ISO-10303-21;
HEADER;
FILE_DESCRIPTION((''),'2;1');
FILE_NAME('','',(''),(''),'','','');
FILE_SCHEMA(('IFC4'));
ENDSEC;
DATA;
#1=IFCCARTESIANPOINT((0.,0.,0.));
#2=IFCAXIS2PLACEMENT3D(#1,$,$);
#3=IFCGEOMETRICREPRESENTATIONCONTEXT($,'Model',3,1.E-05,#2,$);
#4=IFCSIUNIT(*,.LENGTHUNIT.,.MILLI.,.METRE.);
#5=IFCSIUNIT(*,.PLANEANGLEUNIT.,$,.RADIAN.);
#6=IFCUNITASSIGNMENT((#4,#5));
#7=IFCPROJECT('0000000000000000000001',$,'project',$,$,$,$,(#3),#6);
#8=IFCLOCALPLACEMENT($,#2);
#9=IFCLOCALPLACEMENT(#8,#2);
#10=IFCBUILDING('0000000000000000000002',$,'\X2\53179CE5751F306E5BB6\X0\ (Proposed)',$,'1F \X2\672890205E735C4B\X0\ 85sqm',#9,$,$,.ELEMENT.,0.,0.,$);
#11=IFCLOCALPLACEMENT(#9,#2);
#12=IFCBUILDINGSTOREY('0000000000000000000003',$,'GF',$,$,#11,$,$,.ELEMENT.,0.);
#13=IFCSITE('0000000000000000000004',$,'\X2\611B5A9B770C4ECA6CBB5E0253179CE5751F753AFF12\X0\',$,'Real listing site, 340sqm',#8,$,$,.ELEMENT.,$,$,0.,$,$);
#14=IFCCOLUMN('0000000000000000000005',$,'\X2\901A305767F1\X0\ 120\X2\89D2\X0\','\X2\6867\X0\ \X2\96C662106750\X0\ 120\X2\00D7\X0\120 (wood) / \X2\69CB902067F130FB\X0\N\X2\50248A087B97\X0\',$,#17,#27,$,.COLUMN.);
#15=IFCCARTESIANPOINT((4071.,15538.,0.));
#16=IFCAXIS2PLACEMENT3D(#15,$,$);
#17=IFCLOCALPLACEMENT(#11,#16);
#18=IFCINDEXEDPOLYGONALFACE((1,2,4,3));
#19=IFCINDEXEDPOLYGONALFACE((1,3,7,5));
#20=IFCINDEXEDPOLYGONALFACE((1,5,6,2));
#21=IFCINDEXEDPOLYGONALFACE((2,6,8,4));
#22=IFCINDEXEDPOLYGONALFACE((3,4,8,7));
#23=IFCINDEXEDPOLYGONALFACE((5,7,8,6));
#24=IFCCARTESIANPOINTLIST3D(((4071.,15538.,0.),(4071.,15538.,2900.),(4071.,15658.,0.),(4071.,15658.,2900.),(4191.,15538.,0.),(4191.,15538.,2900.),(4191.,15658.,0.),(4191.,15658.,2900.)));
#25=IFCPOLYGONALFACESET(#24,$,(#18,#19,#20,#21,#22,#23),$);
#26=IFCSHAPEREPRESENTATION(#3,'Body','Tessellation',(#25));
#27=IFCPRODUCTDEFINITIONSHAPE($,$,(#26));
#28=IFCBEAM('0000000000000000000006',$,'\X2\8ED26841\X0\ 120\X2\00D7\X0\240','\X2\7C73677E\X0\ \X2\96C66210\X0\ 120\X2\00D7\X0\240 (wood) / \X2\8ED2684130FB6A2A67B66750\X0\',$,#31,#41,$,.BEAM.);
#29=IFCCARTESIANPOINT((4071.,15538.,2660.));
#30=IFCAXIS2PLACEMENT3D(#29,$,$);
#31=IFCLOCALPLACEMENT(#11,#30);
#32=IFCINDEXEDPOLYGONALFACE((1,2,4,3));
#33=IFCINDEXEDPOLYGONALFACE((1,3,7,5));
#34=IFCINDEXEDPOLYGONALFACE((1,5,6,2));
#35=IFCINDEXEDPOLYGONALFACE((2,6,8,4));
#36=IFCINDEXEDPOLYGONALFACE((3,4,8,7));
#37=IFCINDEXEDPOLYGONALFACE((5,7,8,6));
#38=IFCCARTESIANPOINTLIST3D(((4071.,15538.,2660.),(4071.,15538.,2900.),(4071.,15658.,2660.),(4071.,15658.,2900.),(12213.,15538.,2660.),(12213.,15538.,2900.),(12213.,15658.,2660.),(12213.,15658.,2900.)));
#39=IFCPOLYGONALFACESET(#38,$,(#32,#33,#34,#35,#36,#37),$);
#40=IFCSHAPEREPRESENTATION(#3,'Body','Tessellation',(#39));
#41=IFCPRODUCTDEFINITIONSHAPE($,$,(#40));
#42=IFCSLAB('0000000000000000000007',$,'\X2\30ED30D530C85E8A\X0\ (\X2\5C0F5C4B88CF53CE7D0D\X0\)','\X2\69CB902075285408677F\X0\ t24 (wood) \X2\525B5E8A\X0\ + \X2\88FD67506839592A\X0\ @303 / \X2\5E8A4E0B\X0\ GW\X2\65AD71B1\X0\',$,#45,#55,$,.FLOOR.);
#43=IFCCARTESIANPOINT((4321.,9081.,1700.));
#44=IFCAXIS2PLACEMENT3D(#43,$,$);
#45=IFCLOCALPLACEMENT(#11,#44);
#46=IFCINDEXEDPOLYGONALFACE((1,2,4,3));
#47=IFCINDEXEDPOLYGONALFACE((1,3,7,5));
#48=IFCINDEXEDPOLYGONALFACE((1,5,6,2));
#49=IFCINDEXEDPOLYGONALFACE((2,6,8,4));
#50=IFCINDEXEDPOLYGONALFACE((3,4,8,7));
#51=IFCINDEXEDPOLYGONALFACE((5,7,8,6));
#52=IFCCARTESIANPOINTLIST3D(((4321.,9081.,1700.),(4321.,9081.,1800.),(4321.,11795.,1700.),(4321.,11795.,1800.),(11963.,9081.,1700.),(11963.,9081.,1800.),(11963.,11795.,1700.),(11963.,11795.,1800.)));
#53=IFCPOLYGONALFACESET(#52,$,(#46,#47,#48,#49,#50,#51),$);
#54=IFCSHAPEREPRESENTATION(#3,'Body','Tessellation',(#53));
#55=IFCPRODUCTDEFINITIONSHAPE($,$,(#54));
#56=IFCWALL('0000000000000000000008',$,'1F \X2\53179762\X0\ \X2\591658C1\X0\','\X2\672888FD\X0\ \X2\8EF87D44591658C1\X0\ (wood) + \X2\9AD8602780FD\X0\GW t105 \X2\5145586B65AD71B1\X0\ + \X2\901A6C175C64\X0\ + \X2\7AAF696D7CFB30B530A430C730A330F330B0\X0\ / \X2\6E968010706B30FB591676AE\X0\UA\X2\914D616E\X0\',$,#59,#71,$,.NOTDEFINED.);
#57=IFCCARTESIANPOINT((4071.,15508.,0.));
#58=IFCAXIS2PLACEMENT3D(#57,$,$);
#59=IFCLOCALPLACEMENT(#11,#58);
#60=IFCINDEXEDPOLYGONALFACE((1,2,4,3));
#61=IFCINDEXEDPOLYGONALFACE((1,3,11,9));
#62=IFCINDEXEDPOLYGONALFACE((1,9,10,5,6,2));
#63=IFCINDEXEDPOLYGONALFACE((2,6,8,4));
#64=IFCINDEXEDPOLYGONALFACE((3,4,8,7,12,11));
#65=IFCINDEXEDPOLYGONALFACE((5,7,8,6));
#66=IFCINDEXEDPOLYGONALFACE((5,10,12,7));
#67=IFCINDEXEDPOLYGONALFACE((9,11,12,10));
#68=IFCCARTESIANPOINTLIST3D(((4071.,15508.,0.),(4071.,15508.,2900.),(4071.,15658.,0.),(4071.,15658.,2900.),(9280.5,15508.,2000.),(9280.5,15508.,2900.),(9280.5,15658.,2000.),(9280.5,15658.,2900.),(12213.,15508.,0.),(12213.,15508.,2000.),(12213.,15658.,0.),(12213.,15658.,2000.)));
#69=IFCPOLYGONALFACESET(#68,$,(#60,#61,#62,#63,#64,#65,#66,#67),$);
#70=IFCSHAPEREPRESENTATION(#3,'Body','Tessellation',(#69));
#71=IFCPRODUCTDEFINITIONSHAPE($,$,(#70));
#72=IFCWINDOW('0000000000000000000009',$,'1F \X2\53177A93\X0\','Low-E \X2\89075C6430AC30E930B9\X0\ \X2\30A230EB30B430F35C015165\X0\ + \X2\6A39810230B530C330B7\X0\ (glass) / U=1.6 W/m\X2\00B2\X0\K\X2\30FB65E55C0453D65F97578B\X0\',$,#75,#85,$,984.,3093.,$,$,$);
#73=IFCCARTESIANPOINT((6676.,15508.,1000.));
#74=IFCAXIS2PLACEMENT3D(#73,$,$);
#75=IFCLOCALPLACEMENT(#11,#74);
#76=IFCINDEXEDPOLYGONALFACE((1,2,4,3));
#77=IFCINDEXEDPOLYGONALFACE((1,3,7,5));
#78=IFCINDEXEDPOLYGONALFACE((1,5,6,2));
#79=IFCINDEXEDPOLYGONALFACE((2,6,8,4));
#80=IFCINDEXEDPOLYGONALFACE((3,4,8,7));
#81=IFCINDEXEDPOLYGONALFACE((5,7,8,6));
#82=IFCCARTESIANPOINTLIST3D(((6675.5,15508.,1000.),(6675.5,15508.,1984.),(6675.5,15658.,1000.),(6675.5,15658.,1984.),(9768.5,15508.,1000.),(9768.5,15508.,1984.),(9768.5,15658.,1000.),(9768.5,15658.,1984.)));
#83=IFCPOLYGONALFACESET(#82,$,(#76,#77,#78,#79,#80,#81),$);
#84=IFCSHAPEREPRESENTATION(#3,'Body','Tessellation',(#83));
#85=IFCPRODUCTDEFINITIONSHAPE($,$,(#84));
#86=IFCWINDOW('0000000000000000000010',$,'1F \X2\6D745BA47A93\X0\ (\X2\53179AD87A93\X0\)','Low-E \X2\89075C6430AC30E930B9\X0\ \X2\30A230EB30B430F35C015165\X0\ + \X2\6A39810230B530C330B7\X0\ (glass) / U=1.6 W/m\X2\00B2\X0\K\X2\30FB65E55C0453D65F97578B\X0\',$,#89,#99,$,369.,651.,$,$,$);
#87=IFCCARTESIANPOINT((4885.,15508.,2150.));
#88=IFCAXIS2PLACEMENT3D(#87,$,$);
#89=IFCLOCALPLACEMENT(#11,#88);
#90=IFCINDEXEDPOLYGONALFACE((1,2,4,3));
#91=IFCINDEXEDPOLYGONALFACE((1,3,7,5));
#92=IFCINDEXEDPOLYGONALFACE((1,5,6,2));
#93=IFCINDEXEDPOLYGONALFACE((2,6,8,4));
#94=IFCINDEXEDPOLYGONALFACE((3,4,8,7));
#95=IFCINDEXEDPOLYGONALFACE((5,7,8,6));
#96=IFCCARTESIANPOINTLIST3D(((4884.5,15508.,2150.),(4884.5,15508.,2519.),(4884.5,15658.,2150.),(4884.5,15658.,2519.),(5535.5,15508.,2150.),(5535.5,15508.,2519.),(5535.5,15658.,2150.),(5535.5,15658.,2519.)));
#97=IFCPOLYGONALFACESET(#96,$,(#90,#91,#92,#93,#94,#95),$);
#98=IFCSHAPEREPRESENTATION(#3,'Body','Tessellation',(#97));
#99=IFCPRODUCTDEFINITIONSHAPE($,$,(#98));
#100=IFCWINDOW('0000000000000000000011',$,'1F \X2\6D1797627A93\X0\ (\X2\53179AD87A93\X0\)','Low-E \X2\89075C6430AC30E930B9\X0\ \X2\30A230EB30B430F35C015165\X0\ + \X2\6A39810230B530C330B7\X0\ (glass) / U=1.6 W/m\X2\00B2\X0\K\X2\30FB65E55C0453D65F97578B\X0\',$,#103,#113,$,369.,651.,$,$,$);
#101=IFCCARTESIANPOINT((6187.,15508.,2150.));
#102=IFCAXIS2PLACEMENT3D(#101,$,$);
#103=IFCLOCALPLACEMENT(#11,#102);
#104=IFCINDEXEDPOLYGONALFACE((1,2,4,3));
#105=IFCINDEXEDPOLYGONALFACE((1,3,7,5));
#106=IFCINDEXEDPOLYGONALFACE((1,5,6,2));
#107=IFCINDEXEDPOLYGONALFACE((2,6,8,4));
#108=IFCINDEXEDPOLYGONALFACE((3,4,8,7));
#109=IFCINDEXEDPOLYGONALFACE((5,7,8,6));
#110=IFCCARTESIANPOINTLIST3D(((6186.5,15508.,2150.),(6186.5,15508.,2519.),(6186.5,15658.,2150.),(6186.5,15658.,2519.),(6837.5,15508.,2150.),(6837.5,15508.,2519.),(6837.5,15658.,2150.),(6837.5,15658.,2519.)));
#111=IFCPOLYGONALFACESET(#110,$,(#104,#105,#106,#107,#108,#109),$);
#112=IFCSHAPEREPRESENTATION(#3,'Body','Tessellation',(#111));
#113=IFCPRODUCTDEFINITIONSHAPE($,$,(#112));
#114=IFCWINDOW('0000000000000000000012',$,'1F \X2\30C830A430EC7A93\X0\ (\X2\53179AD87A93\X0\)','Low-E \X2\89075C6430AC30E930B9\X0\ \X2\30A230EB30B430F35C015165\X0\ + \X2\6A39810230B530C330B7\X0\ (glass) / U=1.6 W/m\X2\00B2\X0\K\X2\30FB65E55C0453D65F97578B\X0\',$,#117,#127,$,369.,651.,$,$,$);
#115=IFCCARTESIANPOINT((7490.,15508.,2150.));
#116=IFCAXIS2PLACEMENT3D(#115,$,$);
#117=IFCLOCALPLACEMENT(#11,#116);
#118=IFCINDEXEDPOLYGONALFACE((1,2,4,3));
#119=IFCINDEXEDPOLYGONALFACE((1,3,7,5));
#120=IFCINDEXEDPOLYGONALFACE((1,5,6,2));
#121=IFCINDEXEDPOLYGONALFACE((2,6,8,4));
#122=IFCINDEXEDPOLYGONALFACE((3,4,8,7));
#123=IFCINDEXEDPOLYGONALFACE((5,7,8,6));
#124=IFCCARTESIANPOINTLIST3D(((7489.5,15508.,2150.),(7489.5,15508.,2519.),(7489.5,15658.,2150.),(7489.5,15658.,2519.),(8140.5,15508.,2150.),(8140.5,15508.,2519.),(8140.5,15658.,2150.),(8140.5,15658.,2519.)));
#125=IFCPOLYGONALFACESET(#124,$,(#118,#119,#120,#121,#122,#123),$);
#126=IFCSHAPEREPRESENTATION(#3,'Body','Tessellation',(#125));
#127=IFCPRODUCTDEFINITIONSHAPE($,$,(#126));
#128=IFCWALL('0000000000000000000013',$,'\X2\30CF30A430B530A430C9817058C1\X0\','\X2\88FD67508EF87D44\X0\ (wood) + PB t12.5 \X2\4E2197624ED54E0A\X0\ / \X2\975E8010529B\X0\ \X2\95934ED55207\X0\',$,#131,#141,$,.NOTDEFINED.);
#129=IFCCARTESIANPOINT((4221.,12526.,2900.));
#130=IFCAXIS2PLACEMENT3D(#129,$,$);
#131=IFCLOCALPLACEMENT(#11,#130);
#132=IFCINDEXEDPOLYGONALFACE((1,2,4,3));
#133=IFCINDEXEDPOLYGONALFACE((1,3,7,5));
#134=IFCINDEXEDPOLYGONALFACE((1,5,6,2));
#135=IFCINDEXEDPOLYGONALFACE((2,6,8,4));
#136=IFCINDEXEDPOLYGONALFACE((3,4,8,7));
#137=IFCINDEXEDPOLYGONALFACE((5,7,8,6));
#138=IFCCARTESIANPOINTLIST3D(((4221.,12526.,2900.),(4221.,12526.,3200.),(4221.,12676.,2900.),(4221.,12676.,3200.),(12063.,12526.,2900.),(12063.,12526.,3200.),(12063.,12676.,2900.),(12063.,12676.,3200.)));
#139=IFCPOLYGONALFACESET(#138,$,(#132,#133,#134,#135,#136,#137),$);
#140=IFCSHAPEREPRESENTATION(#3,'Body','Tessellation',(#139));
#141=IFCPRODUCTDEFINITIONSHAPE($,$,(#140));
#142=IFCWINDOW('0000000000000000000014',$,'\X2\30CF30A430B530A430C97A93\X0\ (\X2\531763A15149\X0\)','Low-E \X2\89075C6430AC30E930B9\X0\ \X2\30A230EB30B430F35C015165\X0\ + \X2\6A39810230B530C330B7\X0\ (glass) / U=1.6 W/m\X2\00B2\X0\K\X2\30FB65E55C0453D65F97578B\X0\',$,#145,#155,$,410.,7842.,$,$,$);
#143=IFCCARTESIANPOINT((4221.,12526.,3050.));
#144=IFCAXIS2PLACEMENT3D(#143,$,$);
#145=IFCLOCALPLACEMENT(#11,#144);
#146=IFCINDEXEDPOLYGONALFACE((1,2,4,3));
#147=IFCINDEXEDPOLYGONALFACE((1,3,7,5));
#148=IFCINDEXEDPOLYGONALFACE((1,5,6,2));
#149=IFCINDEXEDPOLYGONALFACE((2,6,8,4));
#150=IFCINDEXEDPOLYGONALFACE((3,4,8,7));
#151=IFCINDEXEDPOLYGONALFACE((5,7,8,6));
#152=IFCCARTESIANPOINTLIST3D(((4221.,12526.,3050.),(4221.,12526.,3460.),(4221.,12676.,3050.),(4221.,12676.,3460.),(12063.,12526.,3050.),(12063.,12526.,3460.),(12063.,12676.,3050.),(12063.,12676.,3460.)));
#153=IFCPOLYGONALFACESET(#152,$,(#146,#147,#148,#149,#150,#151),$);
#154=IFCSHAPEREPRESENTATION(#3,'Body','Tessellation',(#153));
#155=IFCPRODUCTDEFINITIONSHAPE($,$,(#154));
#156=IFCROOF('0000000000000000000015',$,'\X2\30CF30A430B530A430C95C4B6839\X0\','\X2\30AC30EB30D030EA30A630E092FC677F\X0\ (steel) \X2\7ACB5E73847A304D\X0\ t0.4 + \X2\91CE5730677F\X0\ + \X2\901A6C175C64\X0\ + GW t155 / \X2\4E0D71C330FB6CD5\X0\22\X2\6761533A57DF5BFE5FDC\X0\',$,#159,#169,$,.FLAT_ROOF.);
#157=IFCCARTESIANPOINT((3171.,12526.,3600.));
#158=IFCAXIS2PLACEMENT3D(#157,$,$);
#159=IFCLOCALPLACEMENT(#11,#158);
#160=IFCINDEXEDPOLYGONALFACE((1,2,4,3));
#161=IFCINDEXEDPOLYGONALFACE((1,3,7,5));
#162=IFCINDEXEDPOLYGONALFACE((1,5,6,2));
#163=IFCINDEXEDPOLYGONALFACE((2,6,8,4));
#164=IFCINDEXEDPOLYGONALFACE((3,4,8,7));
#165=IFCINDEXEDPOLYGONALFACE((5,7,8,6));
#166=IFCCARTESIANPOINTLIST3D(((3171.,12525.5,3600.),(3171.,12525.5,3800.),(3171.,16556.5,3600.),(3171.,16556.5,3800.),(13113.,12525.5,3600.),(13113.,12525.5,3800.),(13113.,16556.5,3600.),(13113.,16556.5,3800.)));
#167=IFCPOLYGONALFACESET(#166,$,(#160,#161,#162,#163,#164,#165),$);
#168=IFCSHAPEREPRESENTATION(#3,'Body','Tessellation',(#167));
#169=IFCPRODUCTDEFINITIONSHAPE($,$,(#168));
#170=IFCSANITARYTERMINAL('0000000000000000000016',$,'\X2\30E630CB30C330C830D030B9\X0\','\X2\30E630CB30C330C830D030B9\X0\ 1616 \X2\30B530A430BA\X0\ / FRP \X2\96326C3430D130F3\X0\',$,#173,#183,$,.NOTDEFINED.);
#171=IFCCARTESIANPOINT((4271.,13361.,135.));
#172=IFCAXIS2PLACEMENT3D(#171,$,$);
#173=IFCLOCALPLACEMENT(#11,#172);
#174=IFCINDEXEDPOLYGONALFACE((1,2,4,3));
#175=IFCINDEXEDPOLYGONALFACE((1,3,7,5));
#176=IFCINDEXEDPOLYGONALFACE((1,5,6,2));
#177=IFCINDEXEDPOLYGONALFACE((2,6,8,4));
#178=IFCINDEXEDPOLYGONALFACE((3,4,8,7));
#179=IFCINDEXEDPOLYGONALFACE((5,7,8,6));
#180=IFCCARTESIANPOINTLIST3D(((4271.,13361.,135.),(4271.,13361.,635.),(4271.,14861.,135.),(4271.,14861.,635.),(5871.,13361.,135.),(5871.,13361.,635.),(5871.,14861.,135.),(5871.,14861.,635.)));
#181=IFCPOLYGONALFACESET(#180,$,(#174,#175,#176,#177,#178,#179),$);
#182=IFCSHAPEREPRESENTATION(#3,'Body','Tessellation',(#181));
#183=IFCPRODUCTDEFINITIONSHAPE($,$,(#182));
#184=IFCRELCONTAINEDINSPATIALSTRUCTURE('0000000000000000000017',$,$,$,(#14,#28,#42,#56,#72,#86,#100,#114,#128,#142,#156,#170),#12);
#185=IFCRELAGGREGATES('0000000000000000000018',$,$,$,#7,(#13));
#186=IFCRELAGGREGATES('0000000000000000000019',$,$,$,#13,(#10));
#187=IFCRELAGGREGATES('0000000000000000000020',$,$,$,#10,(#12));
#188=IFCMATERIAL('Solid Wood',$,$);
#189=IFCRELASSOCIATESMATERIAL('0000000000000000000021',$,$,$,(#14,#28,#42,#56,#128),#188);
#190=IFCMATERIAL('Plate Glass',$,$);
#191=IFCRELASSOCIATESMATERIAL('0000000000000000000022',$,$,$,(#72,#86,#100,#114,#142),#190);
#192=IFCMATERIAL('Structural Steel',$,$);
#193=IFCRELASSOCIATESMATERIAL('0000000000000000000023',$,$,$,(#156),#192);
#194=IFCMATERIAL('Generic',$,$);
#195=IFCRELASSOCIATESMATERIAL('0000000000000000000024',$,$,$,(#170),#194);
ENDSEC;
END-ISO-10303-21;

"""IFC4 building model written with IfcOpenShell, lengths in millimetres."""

from ifc_helpers import new_model, si_unit, frame, frame_2d, origin, place, context, project, spatial, rectangle, extrude, material, element, fill, save


model = new_model("IFC4")

# Units and contexts
model_context = context("Model", 3, precision=1e-05, world=origin())
ifc_project = project(units=[si_unit("LENGTHUNIT", "METRE", prefix="MILLI"), si_unit("PLANEANGLEUNIT", "RADIAN")], contexts=[model_context])

# Site, building, storey
site_placement = place(None, origin())
site = spatial("IfcSite", under=ifc_project, at=site_placement, Name="愛媛県今治市北鳥生町２", ObjectType="Real listing site, 340sqm", CompositionType="ELEMENT", RefElevation=0.0)
building_placement = place(site_placement, origin())
building = spatial("IfcBuilding", under=site, at=building_placement, Name="北鳥生の家 (Proposed)", ObjectType="1F 木造平屋 85sqm", CompositionType="ELEMENT", ElevationOfRefHeight=0.0, ElevationOfTerrain=0.0)
storey_placement = place(building_placement, origin())
storey = spatial("IfcBuildingStorey", under=building, at=storey_placement, Name="GF", CompositionType="ELEMENT", Elevation=0.0)

# Column
ifc_material_1 = material(Name="Solid Wood")
column_1_placement = place(storey_placement, frame((4071.0, 15538.0, 0.0)))
element("IfcColumn", 1, at=column_1_placement, inside=storey, material=ifc_material_1, Name="通し柱 120角", Description="桧 集成材 120×120 (wood) / 構造柱・N値計算", PredefinedType="COLUMN", context=model_context, shape_type="SweptSolid", body=[
    extrude(rectangle(XDim=120.0, YDim=120.0, at=frame_2d((60.0, 60.0))), frame((4071.0, 15538.0, 0.0)), (0.0, 0.0, 1.0), 2900.0),
])

# Beam
beam_1_placement = place(storey_placement, frame((4071.0, 15538.0, 2660.0)))
element("IfcBeam", 2, at=beam_1_placement, inside=storey, material=ifc_material_1, Name="軒桁 120×240", Description="米松 集成 120×240 (wood) / 軒桁・横架材", PredefinedType="BEAM", context=model_context, shape_type="SweptSolid", body=[
    extrude(rectangle(XDim=8142.0, YDim=120.0, at=frame_2d((4071.0, 60.0))), frame((4071.0, 15538.0, 2660.0)), (0.0, 0.0, 1.0), 240.0),
])

# Slab
slab_placement = place(storey_placement, frame((4321.0, 9081.0, 1700.0)))
element("IfcSlab", 3, at=slab_placement, inside=storey, material=ifc_material_1, Name="ロフト床 (小屋裏収納)", Description="構造用合板 t24 (wood) 剛床 + 製材根太 @303 / 床下 GW断熱", PredefinedType="FLOOR", context=model_context, shape_type="SweptSolid", body=[
    extrude(rectangle(XDim=7642.0, YDim=2714.0, at=frame_2d((3821.0, 1357.0))), frame((4321.0, 9081.0, 1700.0)), (0.0, 0.0, 1.0), 100.0),
])

# Wall, openings, windows
wall_1_placement = place(storey_placement, frame((4071.0, 15508.0, 0.0)))
wall_1 = element("IfcWall", 4, at=wall_1_placement, inside=storey, material=ifc_material_1, Name="1F 北面 外壁", Description="木製 軸組外壁 (wood) + 高性能GW t105 充填断熱 + 通気層 + 窯業系サイディング / 準耐火・外皮UA配慮", PredefinedType="NOTDEFINED", context=model_context, shape_type="SweptSolid", body=[
    extrude(rectangle(XDim=8142.0, YDim=150.0, at=frame_2d((4071.0, 75.0))), frame((4071.0, 15508.0, 0.0)), (0.0, 0.0, 1.0), 2900.0),
])
opening_1_placement = place(storey_placement, frame((6676.0, 15508.0, 1000.0)))
opening_1 = element("IfcOpeningElement", 5, at=opening_1_placement, cuts=wall_1, PredefinedType="NOTDEFINED", context=model_context, shape_type="SweptSolid", body=[
    extrude(rectangle(XDim=3093.0, YDim=150.0, at=frame_2d((1546.0, 75.0))), frame((6676.0, 15508.0, 1000.0)), (0.0, 0.0, 1.0), 984.0),
])
opening_2_placement = place(storey_placement, frame((4885.0, 15508.0, 2150.0)))
opening_2 = element("IfcOpeningElement", 6, at=opening_2_placement, cuts=wall_1, PredefinedType="NOTDEFINED", context=model_context, shape_type="SweptSolid", body=[
    extrude(rectangle(XDim=651.0, YDim=150.0, at=frame_2d((325.0, 75.0))), frame((4885.0, 15508.0, 2150.0)), (0.0, 0.0, 1.0), 369.0),
])
opening_3_placement = place(storey_placement, frame((6187.0, 15508.0, 2150.0)))
opening_3 = element("IfcOpeningElement", 7, at=opening_3_placement, cuts=wall_1, PredefinedType="NOTDEFINED", context=model_context, shape_type="SweptSolid", body=[
    extrude(rectangle(XDim=651.0, YDim=150.0, at=frame_2d((325.0, 75.0))), frame((6187.0, 15508.0, 2150.0)), (0.0, 0.0, 1.0), 369.0),
])
opening_4_placement = place(storey_placement, frame((7490.0, 15508.0, 2150.0)))
opening_4 = element("IfcOpeningElement", 8, at=opening_4_placement, cuts=wall_1, PredefinedType="NOTDEFINED", context=model_context, shape_type="SweptSolid", body=[
    extrude(rectangle(XDim=651.0, YDim=150.0, at=frame_2d((325.0, 75.0))), frame((7490.0, 15508.0, 2150.0)), (0.0, 0.0, 1.0), 369.0),
])
ifc_material_2 = material(Name="Plate Glass")
window_1_placement = place(storey_placement, frame((6676.0, 15508.0, 1000.0)))
window_1 = element("IfcWindow", 9, at=window_1_placement, inside=storey, material=ifc_material_2, Name="1F 北窓", Description="Low-E 複層ガラス アルゴン封入 + 樹脂サッシ (glass) / U=1.6 W/m²K・日射取得型", OverallHeight=984.0, OverallWidth=3093.0, context=model_context, shape_type="SweptSolid", body=[
    extrude(rectangle(XDim=3093.0, YDim=150.0, at=frame_2d((1546.0, 75.0))), frame((6676.0, 15508.0, 1000.0)), (0.0, 0.0, 1.0), 984.0),
])
fill(opening_1, window_1)
window_2_placement = place(storey_placement, frame((4885.0, 15508.0, 2150.0)))
window_2 = element("IfcWindow", 10, at=window_2_placement, inside=storey, material=ifc_material_2, Name="1F 浴室窓 (北高窓)", Description="Low-E 複層ガラス アルゴン封入 + 樹脂サッシ (glass) / U=1.6 W/m²K・日射取得型", OverallHeight=369.0, OverallWidth=651.0, context=model_context, shape_type="SweptSolid", body=[
    extrude(rectangle(XDim=651.0, YDim=150.0, at=frame_2d((325.0, 75.0))), frame((4885.0, 15508.0, 2150.0)), (0.0, 0.0, 1.0), 369.0),
])
fill(opening_2, window_2)
window_3_placement = place(storey_placement, frame((6187.0, 15508.0, 2150.0)))
window_3 = element("IfcWindow", 11, at=window_3_placement, inside=storey, material=ifc_material_2, Name="1F 洗面窓 (北高窓)", Description="Low-E 複層ガラス アルゴン封入 + 樹脂サッシ (glass) / U=1.6 W/m²K・日射取得型", OverallHeight=369.0, OverallWidth=651.0, context=model_context, shape_type="SweptSolid", body=[
    extrude(rectangle(XDim=651.0, YDim=150.0, at=frame_2d((325.0, 75.0))), frame((6187.0, 15508.0, 2150.0)), (0.0, 0.0, 1.0), 369.0),
])
fill(opening_3, window_3)
window_4_placement = place(storey_placement, frame((7490.0, 15508.0, 2150.0)))
window_4 = element("IfcWindow", 12, at=window_4_placement, inside=storey, material=ifc_material_2, Name="1F トイレ窓 (北高窓)", Description="Low-E 複層ガラス アルゴン封入 + 樹脂サッシ (glass) / U=1.6 W/m²K・日射取得型", OverallHeight=369.0, OverallWidth=651.0, context=model_context, shape_type="SweptSolid", body=[
    extrude(rectangle(XDim=651.0, YDim=150.0, at=frame_2d((325.0, 75.0))), frame((7490.0, 15508.0, 2150.0)), (0.0, 0.0, 1.0), 369.0),
])
fill(opening_4, window_4)

# Wall, opening, window
wall_2_placement = place(storey_placement, frame((4221.0, 12526.0, 2900.0)))
wall_2 = element("IfcWall", 13, at=wall_2_placement, inside=storey, material=ifc_material_1, Name="ハイサイド腰壁", Description="製材軸組 (wood) + PB t12.5 両面仕上 / 非耐力 間仕切", PredefinedType="NOTDEFINED", context=model_context, shape_type="SweptSolid", body=[
    extrude(rectangle(XDim=7842.0, YDim=150.0, at=frame_2d((3921.0, 75.0))), frame((4221.0, 12526.0, 2900.0)), (0.0, 0.0, 1.0), 700.0),
])
opening_5_placement = place(storey_placement, frame((4221.0, 12526.0, 3050.0)))
opening_5 = element("IfcOpeningElement", 14, at=opening_5_placement, cuts=wall_2, PredefinedType="NOTDEFINED", context=model_context, shape_type="SweptSolid", body=[
    extrude(rectangle(XDim=7842.0, YDim=150.0, at=frame_2d((3921.0, 75.0))), frame((4221.0, 12526.0, 3050.0)), (0.0, 0.0, 1.0), 410.0),
])
window_5_placement = place(storey_placement, frame((4221.0, 12526.0, 3050.0)))
window_5 = element("IfcWindow", 15, at=window_5_placement, inside=storey, material=ifc_material_2, Name="ハイサイド窓 (北採光)", Description="Low-E 複層ガラス アルゴン封入 + 樹脂サッシ (glass) / U=1.6 W/m²K・日射取得型", OverallHeight=410.0, OverallWidth=7842.0, context=model_context, shape_type="SweptSolid", body=[
    extrude(rectangle(XDim=7842.0, YDim=150.0, at=frame_2d((3921.0, 75.0))), frame((4221.0, 12526.0, 3050.0)), (0.0, 0.0, 1.0), 410.0),
])
fill(opening_5, window_5)

# Roof
ifc_material_3 = material(Name="Structural Steel")
roof_placement = place(storey_placement, frame((3171.0, 12526.0, 3600.0)))
element("IfcRoof", 16, at=roof_placement, inside=storey, material=ifc_material_3, Name="ハイサイド屋根", Description="ガルバリウム鋼板 (steel) 立平葺き t0.4 + 野地板 + 通気層 + GW t155 / 不燃・法22条区域対応", PredefinedType="FLAT_ROOF", context=model_context, shape_type="SweptSolid", body=[
    extrude(rectangle(XDim=9942.0, YDim=4031.0, at=frame_2d((4971.0, 2015.0))), frame((3171.0, 12526.0, 3600.0)), (0.0, 0.0, 1.0), 200.0),
])

# Sanitary terminal
ifc_material_4 = material(Name="Generic")
sanitary_terminal_placement = place(storey_placement, frame((4271.0, 13361.0, 135.0)))
element("IfcSanitaryTerminal", 17, at=sanitary_terminal_placement, inside=storey, material=ifc_material_4, Name="ユニットバス", Description="ユニットバス 1616 サイズ / FRP 防水パン", PredefinedType="NOTDEFINED", context=model_context, shape_type="SweptSolid", body=[
    extrude(rectangle(XDim=1600.0, YDim=1500.0, at=frame_2d((800.0, 750.0))), frame((4271.0, 13361.0, 135.0)), (0.0, 0.0, 1.0), 500.0),
])

save(model, "model.ifc")
